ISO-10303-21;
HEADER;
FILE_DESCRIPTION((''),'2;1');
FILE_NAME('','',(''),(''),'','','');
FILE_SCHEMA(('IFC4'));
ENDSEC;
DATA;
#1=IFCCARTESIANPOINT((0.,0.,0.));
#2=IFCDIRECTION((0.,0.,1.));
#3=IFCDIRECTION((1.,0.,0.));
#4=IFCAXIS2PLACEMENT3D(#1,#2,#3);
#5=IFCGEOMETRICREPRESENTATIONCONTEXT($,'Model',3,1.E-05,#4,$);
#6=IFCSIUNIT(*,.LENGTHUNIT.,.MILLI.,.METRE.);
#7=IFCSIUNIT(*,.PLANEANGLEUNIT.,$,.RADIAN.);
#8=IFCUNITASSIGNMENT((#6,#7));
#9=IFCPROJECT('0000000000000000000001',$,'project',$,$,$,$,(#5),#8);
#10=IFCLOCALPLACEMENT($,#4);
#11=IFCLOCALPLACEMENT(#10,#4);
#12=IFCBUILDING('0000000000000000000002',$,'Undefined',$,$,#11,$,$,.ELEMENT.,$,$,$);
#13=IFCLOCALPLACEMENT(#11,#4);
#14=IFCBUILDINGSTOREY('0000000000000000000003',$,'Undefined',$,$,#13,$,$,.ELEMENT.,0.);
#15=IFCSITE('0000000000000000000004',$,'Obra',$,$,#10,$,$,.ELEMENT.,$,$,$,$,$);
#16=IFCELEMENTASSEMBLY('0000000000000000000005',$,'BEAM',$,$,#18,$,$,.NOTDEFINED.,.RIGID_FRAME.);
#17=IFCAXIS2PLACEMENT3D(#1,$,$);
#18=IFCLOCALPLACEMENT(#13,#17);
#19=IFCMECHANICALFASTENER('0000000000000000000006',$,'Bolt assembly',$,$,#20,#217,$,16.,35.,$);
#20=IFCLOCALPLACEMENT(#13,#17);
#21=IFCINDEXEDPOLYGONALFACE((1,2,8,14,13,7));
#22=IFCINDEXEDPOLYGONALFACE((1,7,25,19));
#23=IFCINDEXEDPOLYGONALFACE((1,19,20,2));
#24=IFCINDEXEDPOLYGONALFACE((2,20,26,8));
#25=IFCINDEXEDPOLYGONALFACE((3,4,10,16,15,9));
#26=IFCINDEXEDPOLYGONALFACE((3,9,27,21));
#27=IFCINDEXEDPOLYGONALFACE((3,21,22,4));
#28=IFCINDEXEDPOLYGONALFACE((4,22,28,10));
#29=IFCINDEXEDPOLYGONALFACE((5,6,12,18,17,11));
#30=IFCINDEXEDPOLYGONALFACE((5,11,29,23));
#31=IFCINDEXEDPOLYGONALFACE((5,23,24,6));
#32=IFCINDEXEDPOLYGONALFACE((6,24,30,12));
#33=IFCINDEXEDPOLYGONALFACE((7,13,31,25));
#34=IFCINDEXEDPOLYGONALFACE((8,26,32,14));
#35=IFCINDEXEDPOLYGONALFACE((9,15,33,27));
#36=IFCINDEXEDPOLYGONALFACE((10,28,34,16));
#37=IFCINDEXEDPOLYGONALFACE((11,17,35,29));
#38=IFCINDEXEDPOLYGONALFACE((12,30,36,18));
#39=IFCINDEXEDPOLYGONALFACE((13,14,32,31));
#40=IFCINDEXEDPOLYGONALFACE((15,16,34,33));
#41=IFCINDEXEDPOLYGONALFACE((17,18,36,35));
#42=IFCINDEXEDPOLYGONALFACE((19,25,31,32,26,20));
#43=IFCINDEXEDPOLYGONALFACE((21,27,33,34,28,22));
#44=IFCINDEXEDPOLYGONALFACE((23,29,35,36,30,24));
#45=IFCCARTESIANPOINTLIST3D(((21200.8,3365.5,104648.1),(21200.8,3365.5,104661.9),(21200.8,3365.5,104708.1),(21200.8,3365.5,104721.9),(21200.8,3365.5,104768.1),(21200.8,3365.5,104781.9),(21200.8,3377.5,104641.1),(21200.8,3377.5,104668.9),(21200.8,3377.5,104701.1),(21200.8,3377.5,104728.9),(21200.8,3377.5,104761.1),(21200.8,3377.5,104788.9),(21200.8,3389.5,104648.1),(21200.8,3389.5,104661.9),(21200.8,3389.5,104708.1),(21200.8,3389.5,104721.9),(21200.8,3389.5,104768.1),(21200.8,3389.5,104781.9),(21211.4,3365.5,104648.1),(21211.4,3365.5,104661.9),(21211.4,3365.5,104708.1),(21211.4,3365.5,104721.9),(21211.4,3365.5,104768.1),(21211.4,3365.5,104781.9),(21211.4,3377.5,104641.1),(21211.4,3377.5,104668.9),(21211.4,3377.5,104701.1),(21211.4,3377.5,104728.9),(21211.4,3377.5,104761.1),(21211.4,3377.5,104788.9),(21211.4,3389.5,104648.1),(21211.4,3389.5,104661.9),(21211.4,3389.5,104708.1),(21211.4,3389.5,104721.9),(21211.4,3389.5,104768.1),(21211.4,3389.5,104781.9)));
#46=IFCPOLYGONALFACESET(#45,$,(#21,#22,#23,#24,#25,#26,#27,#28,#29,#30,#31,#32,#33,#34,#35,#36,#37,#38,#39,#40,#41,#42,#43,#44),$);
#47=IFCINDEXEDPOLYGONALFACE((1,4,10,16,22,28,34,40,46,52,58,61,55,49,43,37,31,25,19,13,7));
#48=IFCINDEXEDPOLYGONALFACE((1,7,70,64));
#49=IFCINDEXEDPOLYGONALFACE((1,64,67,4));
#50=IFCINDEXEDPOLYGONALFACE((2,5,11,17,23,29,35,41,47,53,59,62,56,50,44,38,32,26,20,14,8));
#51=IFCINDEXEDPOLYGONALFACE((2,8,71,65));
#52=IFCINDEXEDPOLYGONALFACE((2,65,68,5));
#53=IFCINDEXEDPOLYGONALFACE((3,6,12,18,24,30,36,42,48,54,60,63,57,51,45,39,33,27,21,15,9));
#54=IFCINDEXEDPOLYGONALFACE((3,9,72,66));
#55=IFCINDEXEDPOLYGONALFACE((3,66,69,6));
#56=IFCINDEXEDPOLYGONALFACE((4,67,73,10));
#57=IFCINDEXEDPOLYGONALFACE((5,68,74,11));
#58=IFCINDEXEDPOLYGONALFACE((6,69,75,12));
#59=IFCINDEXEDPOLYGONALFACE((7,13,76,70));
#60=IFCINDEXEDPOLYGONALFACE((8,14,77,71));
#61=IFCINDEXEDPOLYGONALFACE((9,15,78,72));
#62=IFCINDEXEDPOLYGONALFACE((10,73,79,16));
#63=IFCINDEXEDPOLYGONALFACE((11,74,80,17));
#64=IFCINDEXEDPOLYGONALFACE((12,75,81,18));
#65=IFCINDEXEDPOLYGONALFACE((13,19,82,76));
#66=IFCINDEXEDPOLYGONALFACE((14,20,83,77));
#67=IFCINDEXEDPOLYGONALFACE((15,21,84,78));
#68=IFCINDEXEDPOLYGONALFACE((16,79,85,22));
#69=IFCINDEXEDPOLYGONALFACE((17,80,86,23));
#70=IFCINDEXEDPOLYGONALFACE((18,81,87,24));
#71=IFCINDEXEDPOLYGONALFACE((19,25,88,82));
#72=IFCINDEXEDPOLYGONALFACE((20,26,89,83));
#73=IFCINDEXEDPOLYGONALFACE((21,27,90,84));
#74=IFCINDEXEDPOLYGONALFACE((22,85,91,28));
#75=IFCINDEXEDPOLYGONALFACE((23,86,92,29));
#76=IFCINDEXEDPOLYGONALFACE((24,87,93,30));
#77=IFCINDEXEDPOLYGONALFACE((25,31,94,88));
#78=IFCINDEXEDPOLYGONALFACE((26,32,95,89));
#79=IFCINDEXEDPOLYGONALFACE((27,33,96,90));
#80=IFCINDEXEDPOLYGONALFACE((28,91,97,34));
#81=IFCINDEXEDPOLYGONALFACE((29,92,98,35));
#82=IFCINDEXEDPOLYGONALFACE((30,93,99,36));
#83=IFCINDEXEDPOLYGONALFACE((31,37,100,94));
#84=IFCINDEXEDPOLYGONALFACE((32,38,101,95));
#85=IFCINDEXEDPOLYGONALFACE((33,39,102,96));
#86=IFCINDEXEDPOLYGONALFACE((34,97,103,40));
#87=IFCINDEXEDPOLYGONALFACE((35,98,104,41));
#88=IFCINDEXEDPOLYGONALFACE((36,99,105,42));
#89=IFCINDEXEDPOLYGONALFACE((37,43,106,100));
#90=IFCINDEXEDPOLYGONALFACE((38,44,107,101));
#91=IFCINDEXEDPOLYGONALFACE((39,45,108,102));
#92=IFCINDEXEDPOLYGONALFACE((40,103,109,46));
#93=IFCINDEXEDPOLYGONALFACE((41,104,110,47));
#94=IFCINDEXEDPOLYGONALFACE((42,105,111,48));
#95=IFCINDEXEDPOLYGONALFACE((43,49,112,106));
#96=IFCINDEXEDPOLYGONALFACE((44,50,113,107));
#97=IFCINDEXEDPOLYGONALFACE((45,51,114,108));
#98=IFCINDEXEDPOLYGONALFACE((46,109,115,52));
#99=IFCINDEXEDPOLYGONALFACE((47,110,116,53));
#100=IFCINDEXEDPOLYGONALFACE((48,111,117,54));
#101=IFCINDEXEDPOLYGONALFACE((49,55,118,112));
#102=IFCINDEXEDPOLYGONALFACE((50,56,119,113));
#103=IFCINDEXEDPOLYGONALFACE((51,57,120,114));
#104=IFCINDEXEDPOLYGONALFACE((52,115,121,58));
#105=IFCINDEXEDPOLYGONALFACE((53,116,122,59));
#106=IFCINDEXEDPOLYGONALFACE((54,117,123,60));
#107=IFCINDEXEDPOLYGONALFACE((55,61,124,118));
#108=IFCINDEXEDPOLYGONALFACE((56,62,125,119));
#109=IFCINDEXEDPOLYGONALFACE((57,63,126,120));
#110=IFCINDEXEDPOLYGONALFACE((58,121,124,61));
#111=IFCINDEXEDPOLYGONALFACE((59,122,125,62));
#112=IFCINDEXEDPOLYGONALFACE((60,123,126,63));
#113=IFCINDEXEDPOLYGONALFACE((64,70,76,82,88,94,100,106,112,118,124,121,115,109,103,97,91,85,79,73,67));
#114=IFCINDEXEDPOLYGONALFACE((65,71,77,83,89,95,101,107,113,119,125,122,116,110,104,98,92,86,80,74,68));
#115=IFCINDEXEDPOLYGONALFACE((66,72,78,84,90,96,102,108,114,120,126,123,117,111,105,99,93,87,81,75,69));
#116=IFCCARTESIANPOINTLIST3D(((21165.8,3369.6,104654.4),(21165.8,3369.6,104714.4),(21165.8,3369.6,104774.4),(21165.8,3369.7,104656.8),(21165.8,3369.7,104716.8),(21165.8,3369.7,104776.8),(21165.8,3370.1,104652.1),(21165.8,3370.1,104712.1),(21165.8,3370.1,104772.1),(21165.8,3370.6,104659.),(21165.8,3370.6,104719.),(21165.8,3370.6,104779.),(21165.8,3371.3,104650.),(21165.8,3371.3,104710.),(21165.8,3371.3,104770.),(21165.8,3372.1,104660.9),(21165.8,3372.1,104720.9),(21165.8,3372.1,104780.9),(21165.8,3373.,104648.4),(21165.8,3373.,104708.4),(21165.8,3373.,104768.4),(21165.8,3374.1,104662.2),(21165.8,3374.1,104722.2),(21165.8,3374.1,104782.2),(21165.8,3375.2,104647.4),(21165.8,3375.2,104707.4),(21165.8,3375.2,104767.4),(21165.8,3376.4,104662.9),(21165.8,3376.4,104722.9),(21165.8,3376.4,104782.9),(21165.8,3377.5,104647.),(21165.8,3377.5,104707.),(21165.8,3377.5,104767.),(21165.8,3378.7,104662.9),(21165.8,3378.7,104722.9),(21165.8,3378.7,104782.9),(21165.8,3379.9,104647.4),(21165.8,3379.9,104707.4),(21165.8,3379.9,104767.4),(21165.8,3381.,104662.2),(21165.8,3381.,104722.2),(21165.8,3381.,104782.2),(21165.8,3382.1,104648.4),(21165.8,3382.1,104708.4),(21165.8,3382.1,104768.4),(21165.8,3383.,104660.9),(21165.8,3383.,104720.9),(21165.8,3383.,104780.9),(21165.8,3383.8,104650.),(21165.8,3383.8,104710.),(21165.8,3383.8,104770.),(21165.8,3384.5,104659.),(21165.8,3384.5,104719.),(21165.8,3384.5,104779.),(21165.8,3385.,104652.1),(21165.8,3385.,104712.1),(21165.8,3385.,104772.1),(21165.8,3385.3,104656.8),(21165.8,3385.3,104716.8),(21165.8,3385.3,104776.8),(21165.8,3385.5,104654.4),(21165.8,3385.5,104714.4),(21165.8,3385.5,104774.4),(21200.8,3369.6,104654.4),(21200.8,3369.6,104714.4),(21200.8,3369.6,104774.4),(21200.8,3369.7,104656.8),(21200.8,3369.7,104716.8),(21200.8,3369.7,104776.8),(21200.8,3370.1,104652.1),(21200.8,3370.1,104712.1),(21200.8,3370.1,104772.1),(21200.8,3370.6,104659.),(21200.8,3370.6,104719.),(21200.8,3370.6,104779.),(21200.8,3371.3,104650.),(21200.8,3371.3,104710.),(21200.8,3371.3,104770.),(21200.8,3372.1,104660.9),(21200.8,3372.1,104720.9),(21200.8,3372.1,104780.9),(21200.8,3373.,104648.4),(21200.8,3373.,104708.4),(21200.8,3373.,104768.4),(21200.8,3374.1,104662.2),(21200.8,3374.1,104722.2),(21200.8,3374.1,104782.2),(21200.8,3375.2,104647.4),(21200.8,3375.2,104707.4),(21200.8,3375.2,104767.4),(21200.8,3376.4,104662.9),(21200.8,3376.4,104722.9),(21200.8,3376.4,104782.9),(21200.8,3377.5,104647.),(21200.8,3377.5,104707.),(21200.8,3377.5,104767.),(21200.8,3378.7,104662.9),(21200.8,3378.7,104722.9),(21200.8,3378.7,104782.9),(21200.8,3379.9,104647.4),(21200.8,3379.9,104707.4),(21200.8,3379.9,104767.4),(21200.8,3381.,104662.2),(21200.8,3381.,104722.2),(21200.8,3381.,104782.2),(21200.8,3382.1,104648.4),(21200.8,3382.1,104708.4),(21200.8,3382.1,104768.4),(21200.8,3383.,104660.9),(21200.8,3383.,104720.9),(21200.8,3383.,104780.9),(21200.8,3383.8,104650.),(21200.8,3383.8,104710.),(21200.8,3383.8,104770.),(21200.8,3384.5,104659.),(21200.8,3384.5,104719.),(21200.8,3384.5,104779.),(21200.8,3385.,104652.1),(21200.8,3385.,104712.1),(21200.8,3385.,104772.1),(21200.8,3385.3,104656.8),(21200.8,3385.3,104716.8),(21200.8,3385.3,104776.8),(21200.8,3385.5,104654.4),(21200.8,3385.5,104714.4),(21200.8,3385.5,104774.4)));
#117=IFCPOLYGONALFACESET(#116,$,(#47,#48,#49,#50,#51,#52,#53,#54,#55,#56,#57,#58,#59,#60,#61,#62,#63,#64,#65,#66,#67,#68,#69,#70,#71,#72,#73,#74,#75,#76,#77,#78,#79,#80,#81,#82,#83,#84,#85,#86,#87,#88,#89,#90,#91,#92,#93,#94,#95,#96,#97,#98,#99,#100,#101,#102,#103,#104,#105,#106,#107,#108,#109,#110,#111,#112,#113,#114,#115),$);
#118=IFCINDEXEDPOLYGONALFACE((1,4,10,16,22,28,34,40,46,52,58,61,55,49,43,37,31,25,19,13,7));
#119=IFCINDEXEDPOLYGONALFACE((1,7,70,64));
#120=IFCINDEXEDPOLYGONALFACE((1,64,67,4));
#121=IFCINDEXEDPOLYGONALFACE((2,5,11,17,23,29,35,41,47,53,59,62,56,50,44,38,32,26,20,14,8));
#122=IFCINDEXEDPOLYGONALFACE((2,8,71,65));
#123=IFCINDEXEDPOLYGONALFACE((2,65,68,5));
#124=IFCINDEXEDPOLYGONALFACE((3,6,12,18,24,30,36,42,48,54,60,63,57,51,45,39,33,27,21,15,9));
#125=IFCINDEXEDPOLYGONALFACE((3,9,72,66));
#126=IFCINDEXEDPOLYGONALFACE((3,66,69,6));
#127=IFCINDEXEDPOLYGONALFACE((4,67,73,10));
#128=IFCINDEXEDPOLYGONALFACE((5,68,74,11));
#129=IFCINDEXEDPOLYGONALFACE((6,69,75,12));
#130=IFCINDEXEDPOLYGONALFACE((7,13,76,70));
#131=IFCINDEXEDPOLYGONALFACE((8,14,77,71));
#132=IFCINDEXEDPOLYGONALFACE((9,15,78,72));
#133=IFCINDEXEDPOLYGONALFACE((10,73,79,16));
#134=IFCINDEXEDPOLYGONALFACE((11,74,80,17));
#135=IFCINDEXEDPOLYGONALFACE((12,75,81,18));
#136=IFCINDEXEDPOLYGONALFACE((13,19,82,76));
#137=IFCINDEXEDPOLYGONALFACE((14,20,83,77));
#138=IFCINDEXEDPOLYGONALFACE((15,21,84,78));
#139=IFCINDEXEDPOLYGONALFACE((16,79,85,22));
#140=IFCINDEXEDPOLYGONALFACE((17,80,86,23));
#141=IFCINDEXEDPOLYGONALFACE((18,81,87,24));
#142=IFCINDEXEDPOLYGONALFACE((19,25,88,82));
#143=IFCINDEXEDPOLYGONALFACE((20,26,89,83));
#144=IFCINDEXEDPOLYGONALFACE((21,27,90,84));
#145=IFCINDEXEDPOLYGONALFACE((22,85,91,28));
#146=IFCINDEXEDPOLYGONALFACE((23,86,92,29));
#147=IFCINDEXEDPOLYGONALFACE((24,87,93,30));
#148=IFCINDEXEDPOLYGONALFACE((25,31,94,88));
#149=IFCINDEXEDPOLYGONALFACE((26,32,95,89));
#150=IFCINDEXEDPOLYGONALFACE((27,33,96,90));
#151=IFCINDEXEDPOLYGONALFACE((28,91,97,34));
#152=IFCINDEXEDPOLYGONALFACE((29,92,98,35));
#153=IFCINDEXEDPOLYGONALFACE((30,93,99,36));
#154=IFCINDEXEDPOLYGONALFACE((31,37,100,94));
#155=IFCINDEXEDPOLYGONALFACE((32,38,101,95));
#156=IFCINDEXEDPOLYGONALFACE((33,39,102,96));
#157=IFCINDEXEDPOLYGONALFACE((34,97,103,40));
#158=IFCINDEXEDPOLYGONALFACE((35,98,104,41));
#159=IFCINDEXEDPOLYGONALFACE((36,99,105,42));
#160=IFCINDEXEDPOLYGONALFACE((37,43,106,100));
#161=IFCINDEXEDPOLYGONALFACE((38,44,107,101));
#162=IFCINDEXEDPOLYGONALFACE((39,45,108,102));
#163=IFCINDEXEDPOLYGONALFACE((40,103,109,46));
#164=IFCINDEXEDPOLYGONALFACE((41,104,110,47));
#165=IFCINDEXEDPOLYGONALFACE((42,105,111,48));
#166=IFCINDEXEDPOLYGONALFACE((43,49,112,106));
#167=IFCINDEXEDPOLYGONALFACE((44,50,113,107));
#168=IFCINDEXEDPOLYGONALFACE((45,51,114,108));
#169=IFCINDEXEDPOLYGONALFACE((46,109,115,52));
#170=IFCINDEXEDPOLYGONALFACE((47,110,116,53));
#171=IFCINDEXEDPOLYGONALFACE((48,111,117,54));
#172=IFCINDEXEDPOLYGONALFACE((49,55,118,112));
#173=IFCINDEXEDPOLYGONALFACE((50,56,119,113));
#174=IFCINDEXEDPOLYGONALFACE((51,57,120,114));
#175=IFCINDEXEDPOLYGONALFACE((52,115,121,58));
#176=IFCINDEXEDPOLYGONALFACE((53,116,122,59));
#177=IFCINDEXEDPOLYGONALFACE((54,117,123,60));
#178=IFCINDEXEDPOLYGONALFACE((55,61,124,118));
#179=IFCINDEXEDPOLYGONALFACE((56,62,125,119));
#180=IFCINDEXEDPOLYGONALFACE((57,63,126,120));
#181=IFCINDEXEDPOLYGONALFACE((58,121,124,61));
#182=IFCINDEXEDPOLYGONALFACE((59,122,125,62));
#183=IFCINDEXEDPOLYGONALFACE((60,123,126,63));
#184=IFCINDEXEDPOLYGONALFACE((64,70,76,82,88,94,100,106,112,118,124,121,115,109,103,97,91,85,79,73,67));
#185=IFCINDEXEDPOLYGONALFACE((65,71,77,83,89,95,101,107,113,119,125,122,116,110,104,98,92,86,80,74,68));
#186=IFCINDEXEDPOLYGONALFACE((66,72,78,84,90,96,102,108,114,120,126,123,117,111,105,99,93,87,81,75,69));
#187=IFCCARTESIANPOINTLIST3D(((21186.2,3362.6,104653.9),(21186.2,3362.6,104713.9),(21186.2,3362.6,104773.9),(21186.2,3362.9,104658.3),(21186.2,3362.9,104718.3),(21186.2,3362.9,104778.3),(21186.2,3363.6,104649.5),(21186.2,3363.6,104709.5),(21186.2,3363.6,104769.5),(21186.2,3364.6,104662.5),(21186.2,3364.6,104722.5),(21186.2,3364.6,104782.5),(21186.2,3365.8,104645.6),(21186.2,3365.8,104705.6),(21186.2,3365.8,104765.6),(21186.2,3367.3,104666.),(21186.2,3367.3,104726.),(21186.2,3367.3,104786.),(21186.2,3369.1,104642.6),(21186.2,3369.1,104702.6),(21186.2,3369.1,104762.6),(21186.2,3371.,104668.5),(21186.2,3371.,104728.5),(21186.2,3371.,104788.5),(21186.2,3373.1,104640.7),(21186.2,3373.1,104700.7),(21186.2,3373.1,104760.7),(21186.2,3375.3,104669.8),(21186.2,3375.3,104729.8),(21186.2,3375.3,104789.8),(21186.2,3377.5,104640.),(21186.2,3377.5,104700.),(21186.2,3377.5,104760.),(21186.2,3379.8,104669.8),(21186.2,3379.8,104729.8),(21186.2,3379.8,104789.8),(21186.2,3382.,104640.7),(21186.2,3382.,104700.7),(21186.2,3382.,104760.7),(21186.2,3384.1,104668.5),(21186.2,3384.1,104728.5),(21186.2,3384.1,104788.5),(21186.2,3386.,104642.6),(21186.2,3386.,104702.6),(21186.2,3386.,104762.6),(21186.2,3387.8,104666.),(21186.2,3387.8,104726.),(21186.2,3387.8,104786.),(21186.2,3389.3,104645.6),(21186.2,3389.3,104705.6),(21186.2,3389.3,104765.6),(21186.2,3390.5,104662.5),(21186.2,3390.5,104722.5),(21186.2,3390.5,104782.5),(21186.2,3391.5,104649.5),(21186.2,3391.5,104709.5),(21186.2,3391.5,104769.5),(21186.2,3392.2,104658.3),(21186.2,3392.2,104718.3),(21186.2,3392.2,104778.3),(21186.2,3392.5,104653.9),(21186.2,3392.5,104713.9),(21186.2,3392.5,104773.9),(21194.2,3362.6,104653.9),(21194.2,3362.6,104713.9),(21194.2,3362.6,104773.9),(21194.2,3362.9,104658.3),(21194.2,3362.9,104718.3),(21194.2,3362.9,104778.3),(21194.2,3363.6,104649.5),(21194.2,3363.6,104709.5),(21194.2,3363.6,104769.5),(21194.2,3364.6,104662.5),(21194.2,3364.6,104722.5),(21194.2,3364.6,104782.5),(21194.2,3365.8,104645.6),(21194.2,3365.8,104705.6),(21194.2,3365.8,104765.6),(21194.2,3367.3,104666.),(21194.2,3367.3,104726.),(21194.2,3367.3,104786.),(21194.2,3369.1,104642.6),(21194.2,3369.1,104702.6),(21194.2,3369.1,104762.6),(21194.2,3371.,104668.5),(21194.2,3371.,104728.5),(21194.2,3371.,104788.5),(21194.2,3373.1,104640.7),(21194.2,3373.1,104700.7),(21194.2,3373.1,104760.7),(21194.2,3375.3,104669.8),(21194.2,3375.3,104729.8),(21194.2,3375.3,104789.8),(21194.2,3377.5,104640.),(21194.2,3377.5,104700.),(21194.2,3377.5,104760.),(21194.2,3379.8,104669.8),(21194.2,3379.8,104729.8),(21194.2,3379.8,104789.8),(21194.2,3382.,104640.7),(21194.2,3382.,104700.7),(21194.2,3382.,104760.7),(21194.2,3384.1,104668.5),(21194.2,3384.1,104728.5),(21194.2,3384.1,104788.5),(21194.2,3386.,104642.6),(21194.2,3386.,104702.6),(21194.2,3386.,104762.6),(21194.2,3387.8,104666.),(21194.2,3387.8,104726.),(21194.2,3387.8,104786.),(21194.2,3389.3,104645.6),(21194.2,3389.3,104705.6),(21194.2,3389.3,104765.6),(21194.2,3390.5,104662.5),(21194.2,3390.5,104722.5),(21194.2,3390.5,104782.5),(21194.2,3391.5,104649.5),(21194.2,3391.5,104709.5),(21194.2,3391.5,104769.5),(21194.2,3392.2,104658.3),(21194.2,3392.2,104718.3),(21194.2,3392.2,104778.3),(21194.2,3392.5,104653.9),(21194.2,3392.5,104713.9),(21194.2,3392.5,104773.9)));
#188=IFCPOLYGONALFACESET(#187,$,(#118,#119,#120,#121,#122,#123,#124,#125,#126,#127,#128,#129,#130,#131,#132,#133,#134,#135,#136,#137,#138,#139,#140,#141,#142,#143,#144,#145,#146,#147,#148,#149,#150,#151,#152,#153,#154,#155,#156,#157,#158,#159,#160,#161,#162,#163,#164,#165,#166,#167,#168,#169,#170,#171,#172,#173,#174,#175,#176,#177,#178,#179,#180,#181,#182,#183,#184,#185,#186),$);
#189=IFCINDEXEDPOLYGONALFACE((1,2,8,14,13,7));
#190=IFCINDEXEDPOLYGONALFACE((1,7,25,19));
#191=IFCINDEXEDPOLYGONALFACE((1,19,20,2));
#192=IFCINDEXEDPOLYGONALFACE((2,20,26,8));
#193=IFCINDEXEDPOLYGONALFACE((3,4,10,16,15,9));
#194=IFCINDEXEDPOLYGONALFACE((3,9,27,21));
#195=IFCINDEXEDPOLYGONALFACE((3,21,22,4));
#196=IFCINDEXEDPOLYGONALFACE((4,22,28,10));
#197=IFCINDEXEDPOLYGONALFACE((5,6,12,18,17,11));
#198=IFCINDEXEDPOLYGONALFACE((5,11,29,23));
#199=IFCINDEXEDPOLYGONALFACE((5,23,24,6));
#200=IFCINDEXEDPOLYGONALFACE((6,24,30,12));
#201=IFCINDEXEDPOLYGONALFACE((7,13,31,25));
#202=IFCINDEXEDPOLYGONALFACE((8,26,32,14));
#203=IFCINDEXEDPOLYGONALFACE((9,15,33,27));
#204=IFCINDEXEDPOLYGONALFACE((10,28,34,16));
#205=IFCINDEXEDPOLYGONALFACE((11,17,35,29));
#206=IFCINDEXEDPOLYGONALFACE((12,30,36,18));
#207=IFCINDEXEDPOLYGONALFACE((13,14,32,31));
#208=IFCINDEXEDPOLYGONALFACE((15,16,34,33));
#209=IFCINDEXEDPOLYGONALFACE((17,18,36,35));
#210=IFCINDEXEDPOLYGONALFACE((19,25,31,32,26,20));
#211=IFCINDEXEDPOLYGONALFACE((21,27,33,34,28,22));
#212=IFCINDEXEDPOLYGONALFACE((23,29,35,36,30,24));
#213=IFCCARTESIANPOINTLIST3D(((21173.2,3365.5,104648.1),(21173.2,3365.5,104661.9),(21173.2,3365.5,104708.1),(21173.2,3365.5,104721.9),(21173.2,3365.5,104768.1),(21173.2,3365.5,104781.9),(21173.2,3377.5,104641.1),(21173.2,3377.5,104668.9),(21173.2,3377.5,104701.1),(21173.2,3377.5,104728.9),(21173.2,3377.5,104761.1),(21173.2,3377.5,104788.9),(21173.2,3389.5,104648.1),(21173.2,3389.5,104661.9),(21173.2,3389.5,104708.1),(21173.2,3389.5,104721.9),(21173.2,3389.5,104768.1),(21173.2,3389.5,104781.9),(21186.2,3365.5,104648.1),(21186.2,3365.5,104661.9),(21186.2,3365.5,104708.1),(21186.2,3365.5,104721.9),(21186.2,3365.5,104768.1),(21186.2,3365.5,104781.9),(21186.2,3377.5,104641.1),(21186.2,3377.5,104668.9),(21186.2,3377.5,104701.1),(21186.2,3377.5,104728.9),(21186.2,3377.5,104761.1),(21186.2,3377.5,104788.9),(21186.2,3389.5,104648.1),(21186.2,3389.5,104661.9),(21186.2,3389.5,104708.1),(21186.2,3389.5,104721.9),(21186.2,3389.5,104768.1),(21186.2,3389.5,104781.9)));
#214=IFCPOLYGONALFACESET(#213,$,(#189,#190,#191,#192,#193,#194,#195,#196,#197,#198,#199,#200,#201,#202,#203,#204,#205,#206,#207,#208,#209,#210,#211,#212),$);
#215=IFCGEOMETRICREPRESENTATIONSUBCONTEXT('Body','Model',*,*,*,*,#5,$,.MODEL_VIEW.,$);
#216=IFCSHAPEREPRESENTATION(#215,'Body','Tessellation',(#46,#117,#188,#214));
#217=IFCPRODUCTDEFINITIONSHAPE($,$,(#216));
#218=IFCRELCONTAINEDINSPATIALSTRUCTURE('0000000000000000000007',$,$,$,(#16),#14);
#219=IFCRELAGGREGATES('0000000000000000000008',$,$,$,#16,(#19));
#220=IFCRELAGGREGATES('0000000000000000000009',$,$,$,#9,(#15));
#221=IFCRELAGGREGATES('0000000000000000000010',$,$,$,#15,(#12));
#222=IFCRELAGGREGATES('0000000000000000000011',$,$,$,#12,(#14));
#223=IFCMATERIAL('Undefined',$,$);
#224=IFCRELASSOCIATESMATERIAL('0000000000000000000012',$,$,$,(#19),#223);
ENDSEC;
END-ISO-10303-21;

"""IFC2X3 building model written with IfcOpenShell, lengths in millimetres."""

from ifc_helpers import new_model, si_unit, frame, origin_with_axes, origin_2d_with_axis, place, context, subcontext, project, spatial, polyline, circle, outline, extrude, source, transform, mapped, material, element, aggregate, save


model = new_model("IFC2X3")

# Units and contexts
model_context = context("Model", 3, precision=1e-05, world=origin_with_axes())
body_context = subcontext(model_context, "Body", "Model", "MODEL_VIEW")
ifc_project = project(units=[si_unit("LENGTHUNIT", "METRE", prefix="MILLI"), si_unit("PLANEANGLEUNIT", "RADIAN")], contexts=[model_context])

# Site, building, storey
site_placement = place(None, origin_with_axes())
site = spatial("IfcSite", under=ifc_project, at=site_placement, Name="Obra", CompositionType="ELEMENT")
building_placement = place(site_placement, origin_with_axes())
building = spatial("IfcBuilding", under=site, at=building_placement, Name="Undefined", CompositionType="ELEMENT")
storey_placement = place(building_placement, origin_with_axes())
storey = spatial("IfcBuildingStorey", under=building, at=storey_placement, Name="Undefined", CompositionType="ELEMENT", Elevation=0.0)

# Shared definitions
ifc_material_1 = material(Name="Undefined")

# Element assembly
assembly_1_placement = place(storey_placement, origin_with_axes())
assembly_1 = element("IfcElementAssembly", 1, at=assembly_1_placement, inside=storey, Name="BEAM", AssemblyPlace="NOTDEFINED", PredefinedType="RIGID_FRAME")

# Mechanical fastener
shared_shape_1 = source(origin_with_axes(), body_context, "Body", "SweptSolid", [
    extrude(outline(polyline([(13.9, 0.0), (6.9, 12.0), (-6.9, 12.0), (-13.9, 0.0), (-6.9, -12.0), (6.9, -12.0), (13.9, 0.0)])), frame((0.0, -13.9, 0.0), z_axis=(0.0, 1.0, 0.0), x_axis=(1.0, 0.0, 0.0)), (0.0, 0.0, 1.0), 10.6),
    extrude(circle(Radius=8.0, at=origin_2d_with_axis()), frame((0.0, -3.3, 0.0), z_axis=(0.0, 1.0, 0.0), x_axis=(1.0, 0.0, 0.0)), (0.0, 0.0, 1.0), 35.0),
    extrude(circle(Radius=15.0, at=origin_2d_with_axis()), frame((0.0, 3.3, 0.0), z_axis=(0.0, 1.0, 0.0), x_axis=(1.0, 0.0, 0.0)), (0.0, 0.0, 1.0), 8.0),
    extrude(outline(polyline([(13.9, 0.0), (6.9, 12.0), (-6.9, 12.0), (-13.9, 0.0), (-6.9, -12.0), (6.9, -12.0), (13.9, 0.0)])), frame((0.0, 11.3, 0.0), z_axis=(0.0, 1.0, 0.0), x_axis=(1.0, 0.0, 0.0)), (0.0, 0.0, 1.0), 13.0),
])
mechanical_fastener_1_placement = place(assembly_1_placement, frame((21197.5, 3342.5, 104850.0), z_axis=(0.0, 1.0, 0.0), x_axis=(0.0, 0.0, -1.0)))
mechanical_fastener_1 = element("IfcMechanicalFastener", 2, at=mechanical_fastener_1_placement, material=ifc_material_1, Name="Bolt assembly", NominalDiameter=16.0, NominalLength=35.0, context=body_context, shape_type="MappedRepresentation", body=[
    mapped(shared_shape_1, transform((75.0, 0.0, 35.0))),
    mapped(shared_shape_1, transform((135.0, 0.0, 35.0))),
    mapped(shared_shape_1, transform((195.0, 0.0, 35.0))),
])
aggregate(assembly_1, [mechanical_fastener_1])

save(model, "model.ifc")
